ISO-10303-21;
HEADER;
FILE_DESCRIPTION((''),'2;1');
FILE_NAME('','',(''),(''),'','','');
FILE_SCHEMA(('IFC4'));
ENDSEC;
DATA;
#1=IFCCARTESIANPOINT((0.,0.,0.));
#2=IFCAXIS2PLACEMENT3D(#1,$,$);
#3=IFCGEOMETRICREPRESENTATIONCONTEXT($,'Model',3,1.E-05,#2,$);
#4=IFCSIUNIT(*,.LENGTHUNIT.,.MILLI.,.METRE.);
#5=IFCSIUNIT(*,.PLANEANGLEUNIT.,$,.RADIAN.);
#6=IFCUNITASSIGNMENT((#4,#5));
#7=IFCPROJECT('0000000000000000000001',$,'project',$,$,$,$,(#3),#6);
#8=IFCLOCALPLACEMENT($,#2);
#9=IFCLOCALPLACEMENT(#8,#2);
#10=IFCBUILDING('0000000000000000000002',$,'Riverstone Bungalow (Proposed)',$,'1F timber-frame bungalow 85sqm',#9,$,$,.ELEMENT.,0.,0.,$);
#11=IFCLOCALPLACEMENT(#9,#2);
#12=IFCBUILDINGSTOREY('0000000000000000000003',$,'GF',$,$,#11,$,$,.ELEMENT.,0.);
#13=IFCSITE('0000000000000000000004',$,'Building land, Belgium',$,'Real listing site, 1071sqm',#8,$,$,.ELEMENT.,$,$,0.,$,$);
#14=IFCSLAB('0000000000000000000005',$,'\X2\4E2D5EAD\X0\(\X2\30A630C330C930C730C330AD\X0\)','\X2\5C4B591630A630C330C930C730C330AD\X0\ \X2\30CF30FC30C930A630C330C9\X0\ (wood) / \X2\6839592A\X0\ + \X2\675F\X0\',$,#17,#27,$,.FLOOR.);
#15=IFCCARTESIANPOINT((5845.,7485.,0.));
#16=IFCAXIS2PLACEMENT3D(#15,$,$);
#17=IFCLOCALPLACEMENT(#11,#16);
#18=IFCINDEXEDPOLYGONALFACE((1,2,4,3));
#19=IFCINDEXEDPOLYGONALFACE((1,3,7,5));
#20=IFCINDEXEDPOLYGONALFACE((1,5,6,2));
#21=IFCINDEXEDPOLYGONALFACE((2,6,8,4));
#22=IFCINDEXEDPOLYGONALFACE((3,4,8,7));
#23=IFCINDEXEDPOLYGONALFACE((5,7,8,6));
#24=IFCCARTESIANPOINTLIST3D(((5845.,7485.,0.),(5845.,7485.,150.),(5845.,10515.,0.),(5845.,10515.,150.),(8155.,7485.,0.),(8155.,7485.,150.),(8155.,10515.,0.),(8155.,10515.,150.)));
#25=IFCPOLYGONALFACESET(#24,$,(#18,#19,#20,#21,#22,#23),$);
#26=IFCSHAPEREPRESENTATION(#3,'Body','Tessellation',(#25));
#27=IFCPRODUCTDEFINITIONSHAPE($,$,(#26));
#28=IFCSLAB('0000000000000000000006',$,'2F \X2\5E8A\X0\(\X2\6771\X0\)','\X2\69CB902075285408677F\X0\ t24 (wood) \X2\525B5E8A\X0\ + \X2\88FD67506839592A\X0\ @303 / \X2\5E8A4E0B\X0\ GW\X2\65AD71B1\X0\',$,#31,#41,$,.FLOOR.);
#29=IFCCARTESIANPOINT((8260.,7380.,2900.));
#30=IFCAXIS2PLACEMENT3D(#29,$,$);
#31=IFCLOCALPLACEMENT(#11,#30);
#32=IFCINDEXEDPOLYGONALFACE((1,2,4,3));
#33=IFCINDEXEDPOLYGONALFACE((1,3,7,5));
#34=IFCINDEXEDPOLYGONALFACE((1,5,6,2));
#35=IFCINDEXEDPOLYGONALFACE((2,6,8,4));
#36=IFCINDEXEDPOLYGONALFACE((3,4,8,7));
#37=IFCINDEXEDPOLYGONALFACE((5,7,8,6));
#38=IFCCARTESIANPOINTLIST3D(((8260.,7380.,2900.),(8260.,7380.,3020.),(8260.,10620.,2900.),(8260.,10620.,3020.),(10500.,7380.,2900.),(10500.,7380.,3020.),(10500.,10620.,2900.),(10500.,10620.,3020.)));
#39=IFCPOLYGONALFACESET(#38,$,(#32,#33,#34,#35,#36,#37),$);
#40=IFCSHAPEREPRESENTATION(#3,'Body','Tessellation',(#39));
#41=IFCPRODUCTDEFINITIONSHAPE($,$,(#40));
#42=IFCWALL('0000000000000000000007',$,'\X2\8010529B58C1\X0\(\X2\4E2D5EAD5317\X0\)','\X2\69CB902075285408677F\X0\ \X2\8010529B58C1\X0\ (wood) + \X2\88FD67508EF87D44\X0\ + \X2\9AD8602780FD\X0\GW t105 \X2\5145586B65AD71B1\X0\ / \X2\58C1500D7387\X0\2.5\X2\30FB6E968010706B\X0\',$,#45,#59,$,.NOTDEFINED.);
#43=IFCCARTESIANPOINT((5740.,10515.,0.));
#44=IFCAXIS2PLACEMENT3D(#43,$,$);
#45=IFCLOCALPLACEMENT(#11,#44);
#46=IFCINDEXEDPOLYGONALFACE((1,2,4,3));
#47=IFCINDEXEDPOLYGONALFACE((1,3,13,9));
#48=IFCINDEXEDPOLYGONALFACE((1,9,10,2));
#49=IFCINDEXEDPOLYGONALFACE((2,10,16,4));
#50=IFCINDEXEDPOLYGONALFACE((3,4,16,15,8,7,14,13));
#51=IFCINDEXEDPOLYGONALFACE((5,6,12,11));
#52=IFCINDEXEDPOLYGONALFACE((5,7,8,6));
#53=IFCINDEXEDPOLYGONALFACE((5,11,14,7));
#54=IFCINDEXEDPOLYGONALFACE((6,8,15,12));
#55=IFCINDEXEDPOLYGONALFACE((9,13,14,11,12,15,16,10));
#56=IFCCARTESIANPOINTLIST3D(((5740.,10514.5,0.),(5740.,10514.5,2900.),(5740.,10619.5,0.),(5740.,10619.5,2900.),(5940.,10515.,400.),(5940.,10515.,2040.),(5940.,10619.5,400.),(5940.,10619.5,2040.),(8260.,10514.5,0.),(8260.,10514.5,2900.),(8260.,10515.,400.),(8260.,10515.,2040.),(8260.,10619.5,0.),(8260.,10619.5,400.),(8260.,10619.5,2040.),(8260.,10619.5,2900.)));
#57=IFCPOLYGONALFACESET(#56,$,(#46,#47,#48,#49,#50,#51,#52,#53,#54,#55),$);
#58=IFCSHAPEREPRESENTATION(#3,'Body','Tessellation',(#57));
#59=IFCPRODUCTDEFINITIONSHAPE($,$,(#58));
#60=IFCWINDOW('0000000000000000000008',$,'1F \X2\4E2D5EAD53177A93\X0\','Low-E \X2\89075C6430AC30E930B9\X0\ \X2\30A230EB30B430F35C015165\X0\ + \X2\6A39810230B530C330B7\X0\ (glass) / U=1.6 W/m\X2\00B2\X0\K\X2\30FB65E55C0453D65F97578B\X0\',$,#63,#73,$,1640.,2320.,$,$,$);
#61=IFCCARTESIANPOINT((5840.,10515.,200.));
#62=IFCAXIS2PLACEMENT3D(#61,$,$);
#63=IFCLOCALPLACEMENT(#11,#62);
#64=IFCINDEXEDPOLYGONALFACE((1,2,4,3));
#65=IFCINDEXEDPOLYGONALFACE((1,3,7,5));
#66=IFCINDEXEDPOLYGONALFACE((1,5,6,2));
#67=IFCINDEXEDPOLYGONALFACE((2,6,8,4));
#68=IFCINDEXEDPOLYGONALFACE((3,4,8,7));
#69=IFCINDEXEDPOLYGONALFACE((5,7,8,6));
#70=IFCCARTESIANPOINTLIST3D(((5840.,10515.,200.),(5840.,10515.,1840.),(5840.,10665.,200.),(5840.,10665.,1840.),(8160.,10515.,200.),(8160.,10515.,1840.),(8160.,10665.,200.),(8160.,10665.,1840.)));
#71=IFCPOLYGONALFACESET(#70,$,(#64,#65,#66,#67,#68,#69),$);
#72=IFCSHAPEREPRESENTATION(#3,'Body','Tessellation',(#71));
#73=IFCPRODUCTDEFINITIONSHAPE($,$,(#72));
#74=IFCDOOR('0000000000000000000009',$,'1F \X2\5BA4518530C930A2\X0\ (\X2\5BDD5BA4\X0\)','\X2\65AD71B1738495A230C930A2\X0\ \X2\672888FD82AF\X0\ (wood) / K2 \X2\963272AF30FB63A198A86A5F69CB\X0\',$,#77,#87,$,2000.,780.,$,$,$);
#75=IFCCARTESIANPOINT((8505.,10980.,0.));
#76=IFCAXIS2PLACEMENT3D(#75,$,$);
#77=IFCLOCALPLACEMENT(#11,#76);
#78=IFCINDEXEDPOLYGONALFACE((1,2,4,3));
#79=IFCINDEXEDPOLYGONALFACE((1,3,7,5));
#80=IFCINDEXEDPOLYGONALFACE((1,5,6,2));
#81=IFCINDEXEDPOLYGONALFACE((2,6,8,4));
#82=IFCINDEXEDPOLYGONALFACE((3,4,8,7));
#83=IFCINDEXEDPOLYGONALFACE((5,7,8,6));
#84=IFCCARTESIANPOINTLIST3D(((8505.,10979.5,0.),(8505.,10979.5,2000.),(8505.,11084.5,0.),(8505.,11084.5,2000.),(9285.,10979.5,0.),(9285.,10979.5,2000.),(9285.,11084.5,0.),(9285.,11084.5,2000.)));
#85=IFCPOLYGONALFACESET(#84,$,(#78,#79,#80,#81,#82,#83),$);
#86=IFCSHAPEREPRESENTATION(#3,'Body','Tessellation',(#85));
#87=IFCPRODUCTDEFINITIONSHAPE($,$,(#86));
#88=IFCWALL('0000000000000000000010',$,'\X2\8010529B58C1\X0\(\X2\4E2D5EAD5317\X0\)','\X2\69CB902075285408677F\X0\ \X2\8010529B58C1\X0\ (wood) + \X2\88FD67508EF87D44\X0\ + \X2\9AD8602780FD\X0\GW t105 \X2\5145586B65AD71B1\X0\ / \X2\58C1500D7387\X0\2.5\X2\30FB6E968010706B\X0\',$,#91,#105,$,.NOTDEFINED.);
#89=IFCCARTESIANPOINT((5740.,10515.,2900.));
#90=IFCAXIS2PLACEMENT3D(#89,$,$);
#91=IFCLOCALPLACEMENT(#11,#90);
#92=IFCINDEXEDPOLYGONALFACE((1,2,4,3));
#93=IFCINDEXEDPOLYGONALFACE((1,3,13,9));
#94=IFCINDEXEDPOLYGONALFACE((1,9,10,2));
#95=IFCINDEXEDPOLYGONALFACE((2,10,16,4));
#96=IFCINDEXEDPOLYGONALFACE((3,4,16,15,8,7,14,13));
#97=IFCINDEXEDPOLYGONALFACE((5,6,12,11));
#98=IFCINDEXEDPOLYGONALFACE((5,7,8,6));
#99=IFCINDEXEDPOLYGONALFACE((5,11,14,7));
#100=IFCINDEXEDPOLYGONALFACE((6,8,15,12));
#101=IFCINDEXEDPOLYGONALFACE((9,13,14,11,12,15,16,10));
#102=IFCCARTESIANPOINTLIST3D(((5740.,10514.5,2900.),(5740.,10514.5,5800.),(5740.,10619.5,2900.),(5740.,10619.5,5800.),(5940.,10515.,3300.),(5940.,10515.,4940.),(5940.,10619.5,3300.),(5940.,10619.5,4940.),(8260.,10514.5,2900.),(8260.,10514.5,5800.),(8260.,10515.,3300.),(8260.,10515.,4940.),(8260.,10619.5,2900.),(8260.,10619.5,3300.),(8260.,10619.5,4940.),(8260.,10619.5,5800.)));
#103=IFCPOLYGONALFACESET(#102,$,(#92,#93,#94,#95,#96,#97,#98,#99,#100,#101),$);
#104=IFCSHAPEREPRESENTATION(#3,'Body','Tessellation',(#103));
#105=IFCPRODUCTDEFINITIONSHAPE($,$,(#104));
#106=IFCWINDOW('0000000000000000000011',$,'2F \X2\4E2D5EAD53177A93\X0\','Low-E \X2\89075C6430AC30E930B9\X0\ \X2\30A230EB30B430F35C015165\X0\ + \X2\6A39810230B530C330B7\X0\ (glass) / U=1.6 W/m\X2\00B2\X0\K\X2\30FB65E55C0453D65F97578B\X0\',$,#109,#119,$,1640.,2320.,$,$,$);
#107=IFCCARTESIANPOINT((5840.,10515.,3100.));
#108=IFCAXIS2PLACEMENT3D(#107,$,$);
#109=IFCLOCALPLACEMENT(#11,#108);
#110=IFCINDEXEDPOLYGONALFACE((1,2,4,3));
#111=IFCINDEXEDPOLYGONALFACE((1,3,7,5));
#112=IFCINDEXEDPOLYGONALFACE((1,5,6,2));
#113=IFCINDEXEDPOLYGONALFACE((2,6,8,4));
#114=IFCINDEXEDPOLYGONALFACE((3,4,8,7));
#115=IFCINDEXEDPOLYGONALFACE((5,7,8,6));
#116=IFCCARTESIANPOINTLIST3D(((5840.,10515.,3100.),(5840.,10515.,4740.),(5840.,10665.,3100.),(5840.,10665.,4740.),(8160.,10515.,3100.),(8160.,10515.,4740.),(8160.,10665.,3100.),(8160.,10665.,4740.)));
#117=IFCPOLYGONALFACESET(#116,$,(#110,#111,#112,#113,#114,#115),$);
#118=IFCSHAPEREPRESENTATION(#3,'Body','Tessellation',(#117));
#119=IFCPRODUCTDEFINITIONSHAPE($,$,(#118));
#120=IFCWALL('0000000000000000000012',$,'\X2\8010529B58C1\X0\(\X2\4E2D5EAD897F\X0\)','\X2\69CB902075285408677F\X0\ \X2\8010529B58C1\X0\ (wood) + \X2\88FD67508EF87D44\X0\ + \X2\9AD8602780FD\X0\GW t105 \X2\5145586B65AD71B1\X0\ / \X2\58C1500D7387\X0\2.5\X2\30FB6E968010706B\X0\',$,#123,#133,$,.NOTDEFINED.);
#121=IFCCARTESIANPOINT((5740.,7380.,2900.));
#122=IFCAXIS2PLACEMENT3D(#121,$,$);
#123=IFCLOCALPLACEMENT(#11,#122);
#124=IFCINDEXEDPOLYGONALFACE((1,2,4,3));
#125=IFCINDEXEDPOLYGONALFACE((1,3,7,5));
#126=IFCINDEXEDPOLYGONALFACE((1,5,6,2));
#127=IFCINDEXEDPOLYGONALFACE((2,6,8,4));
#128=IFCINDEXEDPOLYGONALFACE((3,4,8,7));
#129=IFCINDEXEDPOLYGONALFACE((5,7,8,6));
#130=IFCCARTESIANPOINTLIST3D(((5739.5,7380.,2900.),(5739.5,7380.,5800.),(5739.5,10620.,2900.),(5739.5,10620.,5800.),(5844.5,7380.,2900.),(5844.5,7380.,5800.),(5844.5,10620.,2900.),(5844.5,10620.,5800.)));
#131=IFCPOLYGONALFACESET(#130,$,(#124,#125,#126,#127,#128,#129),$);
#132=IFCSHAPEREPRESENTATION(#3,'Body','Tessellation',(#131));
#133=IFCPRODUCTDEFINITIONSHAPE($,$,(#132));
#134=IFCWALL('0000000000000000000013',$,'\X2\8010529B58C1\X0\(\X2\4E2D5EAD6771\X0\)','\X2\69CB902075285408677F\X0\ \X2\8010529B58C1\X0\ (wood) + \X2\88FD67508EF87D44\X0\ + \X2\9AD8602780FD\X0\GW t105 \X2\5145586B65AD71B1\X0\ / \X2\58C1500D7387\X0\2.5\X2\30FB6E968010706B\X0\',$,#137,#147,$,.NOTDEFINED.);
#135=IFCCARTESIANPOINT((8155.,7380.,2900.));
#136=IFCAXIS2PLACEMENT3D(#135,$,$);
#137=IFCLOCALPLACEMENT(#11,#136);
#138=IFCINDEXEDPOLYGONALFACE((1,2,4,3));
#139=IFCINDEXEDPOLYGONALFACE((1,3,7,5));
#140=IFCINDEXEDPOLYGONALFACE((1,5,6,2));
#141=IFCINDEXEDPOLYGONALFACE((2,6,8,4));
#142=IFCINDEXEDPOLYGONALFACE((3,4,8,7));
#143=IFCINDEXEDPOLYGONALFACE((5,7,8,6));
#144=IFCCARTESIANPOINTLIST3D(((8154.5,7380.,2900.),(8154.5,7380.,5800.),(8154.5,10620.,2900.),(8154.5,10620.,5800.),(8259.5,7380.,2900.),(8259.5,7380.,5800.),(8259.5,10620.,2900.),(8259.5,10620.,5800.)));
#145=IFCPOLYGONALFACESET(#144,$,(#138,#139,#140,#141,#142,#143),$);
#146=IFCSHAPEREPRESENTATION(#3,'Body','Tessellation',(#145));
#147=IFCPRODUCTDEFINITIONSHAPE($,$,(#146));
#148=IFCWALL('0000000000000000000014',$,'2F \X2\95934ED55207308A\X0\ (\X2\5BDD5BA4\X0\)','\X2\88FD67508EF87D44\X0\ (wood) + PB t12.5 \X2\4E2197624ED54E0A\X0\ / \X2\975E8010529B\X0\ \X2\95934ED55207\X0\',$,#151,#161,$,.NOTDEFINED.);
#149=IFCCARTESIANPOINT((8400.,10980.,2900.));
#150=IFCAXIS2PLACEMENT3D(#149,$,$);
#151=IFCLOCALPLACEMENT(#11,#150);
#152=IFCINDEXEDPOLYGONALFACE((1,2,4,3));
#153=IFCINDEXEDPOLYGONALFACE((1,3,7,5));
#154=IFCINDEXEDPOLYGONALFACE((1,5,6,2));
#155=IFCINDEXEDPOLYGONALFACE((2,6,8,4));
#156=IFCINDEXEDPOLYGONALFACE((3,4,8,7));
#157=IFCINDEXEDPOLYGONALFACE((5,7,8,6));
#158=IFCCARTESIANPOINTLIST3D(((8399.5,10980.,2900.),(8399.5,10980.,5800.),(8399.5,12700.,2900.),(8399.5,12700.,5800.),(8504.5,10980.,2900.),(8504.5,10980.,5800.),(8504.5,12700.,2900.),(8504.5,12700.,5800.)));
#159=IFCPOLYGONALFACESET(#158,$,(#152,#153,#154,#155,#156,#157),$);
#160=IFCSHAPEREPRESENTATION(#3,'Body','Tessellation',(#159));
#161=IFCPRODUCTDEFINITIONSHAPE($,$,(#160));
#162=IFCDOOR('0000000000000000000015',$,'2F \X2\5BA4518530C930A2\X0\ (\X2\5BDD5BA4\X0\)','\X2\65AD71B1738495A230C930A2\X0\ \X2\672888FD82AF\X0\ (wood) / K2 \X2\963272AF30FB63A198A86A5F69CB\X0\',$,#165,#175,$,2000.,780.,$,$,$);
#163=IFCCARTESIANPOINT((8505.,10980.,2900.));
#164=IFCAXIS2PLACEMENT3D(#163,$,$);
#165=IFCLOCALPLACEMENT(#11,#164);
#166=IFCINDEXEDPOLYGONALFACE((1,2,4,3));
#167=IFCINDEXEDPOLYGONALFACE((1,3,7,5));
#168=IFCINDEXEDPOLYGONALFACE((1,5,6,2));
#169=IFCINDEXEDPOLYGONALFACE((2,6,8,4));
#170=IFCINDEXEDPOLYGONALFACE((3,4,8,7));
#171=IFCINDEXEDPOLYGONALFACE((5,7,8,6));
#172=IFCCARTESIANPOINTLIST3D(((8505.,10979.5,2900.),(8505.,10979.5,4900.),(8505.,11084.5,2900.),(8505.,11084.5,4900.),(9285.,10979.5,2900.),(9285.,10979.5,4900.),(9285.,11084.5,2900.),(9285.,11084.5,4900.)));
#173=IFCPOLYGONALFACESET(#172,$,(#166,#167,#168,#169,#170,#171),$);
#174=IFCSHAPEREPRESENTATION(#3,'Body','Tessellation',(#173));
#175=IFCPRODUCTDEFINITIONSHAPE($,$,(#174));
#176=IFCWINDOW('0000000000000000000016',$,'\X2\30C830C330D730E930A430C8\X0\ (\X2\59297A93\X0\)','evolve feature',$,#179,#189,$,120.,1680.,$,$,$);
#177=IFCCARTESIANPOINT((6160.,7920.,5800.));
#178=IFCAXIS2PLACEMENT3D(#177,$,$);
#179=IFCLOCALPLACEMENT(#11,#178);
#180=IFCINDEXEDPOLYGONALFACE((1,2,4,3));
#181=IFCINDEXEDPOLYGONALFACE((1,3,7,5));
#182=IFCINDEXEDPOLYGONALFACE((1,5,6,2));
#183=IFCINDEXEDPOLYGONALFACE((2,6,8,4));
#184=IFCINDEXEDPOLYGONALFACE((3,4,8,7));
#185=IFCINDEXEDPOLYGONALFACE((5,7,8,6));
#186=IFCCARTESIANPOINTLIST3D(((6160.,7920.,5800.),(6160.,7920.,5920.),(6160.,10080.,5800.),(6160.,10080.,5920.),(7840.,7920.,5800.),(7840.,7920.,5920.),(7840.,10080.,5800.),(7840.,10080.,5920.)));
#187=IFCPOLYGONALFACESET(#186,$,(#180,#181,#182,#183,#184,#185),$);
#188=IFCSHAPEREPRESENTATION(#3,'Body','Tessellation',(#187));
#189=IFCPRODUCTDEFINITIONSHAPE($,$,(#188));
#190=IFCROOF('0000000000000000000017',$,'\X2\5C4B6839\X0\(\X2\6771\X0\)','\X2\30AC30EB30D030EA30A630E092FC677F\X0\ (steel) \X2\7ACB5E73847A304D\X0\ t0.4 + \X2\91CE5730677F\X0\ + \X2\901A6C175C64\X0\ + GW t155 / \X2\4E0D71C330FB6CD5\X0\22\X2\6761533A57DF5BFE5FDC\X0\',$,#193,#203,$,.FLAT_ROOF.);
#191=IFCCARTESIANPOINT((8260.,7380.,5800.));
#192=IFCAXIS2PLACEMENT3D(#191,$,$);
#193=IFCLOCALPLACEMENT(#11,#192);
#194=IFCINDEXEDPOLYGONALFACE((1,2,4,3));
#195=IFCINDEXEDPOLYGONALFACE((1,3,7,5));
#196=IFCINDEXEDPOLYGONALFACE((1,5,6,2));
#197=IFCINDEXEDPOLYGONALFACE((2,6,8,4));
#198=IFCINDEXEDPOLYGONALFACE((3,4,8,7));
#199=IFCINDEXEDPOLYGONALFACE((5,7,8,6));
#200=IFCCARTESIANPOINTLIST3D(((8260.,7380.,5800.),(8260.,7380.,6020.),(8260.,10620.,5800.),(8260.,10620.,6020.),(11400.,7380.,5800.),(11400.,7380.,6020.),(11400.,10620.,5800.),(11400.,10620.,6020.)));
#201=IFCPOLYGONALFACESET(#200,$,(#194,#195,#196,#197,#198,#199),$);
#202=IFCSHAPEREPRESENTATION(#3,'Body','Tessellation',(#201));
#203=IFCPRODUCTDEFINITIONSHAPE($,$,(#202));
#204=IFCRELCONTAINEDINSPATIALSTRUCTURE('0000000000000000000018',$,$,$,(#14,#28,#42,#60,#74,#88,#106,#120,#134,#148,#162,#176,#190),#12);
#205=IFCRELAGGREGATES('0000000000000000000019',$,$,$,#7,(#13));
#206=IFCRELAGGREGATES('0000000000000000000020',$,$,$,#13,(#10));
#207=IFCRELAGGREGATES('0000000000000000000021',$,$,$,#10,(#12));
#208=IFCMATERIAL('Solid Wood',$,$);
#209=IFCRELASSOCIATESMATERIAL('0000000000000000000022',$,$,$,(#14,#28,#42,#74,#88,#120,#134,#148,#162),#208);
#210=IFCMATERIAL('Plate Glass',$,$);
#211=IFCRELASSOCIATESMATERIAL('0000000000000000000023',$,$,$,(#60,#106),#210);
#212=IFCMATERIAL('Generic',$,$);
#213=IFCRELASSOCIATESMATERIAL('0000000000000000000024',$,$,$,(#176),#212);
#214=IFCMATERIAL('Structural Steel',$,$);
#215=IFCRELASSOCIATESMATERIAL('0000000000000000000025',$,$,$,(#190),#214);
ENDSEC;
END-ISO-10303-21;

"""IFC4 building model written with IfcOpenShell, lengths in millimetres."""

from ifc_helpers import new_model, si_unit, frame, frame_2d, origin, place, context, project, spatial, rectangle, extrude, material, element, fill, save


model = new_model("IFC4")

# Units and contexts
model_context = context("Model", 3, precision=1e-05, world=origin())
ifc_project = project(units=[si_unit("LENGTHUNIT", "METRE", prefix="MILLI"), si_unit("PLANEANGLEUNIT", "RADIAN")], contexts=[model_context])

# Site, building, storey
site_placement = place(None, origin())
site = spatial("IfcSite", under=ifc_project, at=site_placement, Name="Building land, Belgium", ObjectType="Real listing site, 1071sqm", CompositionType="ELEMENT", RefElevation=0.0)
building_placement = place(site_placement, origin())
building = spatial("IfcBuilding", under=site, at=building_placement, Name="Riverstone Bungalow (Proposed)", ObjectType="1F timber-frame bungalow 85sqm", CompositionType="ELEMENT", ElevationOfRefHeight=0.0, ElevationOfTerrain=0.0)
storey_placement = place(building_placement, origin())
storey = spatial("IfcBuildingStorey", under=building, at=storey_placement, Name="GF", CompositionType="ELEMENT", Elevation=0.0)

# Slabs
ifc_material_1 = material(Name="Solid Wood")
slab_1_placement = place(storey_placement, frame((5845.0, 7485.0, 0.0)))
element("IfcSlab", 1, at=slab_1_placement, inside=storey, material=ifc_material_1, Name="中庭(ウッドデッキ)", Description="屋外ウッドデッキ ハードウッド (wood) / 根太 + 束", PredefinedType="FLOOR", context=model_context, shape_type="SweptSolid", body=[
    extrude(rectangle(XDim=2310.0, YDim=3030.0, at=frame_2d((1155.0, 1515.0))), frame((5845.0, 7485.0, 0.0)), (0.0, 0.0, 1.0), 150.0),
])
slab_2_placement = place(storey_placement, frame((8260.0, 7380.0, 2900.0)))
element("IfcSlab", 2, at=slab_2_placement, inside=storey, material=ifc_material_1, Name="2F 床(東)", Description="構造用合板 t24 (wood) 剛床 + 製材根太 @303 / 床下 GW断熱", PredefinedType="FLOOR", context=model_context, shape_type="SweptSolid", body=[
    extrude(rectangle(XDim=2240.0, YDim=3240.0, at=frame_2d((1120.0, 1620.0))), frame((8260.0, 7380.0, 2900.0)), (0.0, 0.0, 1.0), 120.0),
])

# Wall, opening, window
wall_1_placement = place(storey_placement, frame((5740.0, 10515.0, 0.0)))
wall_1 = element("IfcWall", 3, at=wall_1_placement, inside=storey, material=ifc_material_1, Name="耐力壁(中庭北)", Description="構造用合板 耐力壁 (wood) + 製材軸組 + 高性能GW t105 充填断熱 / 壁倍率2.5・準耐火", PredefinedType="NOTDEFINED", context=model_context, shape_type="SweptSolid", body=[
    extrude(rectangle(XDim=2520.0, YDim=105.0, at=frame_2d((1260.0, 52.0))), frame((5740.0, 10515.0, 0.0)), (0.0, 0.0, 1.0), 2900.0),
])
opening_1_placement = place(storey_placement, frame((5840.0, 10515.0, 200.0)))
opening_1 = element("IfcOpeningElement", 4, at=opening_1_placement, cuts=wall_1, PredefinedType="NOTDEFINED", context=model_context, shape_type="SweptSolid", body=[
    extrude(rectangle(XDim=2320.0, YDim=150.0, at=frame_2d((1160.0, 75.0))), frame((5840.0, 10515.0, 200.0)), (0.0, 0.0, 1.0), 1640.0),
])
ifc_material_2 = material(Name="Plate Glass")
window_1_placement = place(storey_placement, frame((5840.0, 10515.0, 200.0)))
window_1 = element("IfcWindow", 5, at=window_1_placement, inside=storey, material=ifc_material_2, Name="1F 中庭北窓", Description="Low-E 複層ガラス アルゴン封入 + 樹脂サッシ (glass) / U=1.6 W/m²K・日射取得型", OverallHeight=1640.0, OverallWidth=2320.0, context=model_context, shape_type="SweptSolid", body=[
    extrude(rectangle(XDim=2320.0, YDim=150.0, at=frame_2d((1160.0, 75.0))), frame((5840.0, 10515.0, 200.0)), (0.0, 0.0, 1.0), 1640.0),
])
fill(opening_1, window_1)

# Door
door_1_placement = place(storey_placement, frame((8505.0, 10980.0, 0.0)))
element("IfcDoor", 6, at=door_1_placement, inside=storey, material=ifc_material_1, Name="1F 室内ドア (寝室)", Description="断熱玄関ドア 木製芯 (wood) / K2 防犯・採風機構", OverallHeight=2000.0, OverallWidth=780.0, context=model_context, shape_type="SweptSolid", body=[
    extrude(rectangle(XDim=780.0, YDim=105.0, at=frame_2d((390.0, 52.0))), frame((8505.0, 10980.0, 0.0)), (0.0, 0.0, 1.0), 2000.0),
])

# Wall, opening, window
wall_2_placement = place(storey_placement, frame((5740.0, 10515.0, 2900.0)))
wall_2 = element("IfcWall", 7, at=wall_2_placement, inside=storey, material=ifc_material_1, Name="耐力壁(中庭北)", Description="構造用合板 耐力壁 (wood) + 製材軸組 + 高性能GW t105 充填断熱 / 壁倍率2.5・準耐火", PredefinedType="NOTDEFINED", context=model_context, shape_type="SweptSolid", body=[
    extrude(rectangle(XDim=2520.0, YDim=105.0, at=frame_2d((1260.0, 52.0))), frame((5740.0, 10515.0, 2900.0)), (0.0, 0.0, 1.0), 2900.0),
])
opening_2_placement = place(storey_placement, frame((5840.0, 10515.0, 3100.0)))
opening_2 = element("IfcOpeningElement", 8, at=opening_2_placement, cuts=wall_2, PredefinedType="NOTDEFINED", context=model_context, shape_type="SweptSolid", body=[
    extrude(rectangle(XDim=2320.0, YDim=150.0, at=frame_2d((1160.0, 75.0))), frame((5840.0, 10515.0, 3100.0)), (0.0, 0.0, 1.0), 1640.0),
])
window_2_placement = place(storey_placement, frame((5840.0, 10515.0, 3100.0)))
window_2 = element("IfcWindow", 9, at=window_2_placement, inside=storey, material=ifc_material_2, Name="2F 中庭北窓", Description="Low-E 複層ガラス アルゴン封入 + 樹脂サッシ (glass) / U=1.6 W/m²K・日射取得型", OverallHeight=1640.0, OverallWidth=2320.0, context=model_context, shape_type="SweptSolid", body=[
    extrude(rectangle(XDim=2320.0, YDim=150.0, at=frame_2d((1160.0, 75.0))), frame((5840.0, 10515.0, 3100.0)), (0.0, 0.0, 1.0), 1640.0),
])
fill(opening_2, window_2)

# Walls
wall_3_placement = place(storey_placement, frame((5740.0, 7380.0, 2900.0)))
element("IfcWall", 10, at=wall_3_placement, inside=storey, material=ifc_material_1, Name="耐力壁(中庭西)", Description="構造用合板 耐力壁 (wood) + 製材軸組 + 高性能GW t105 充填断熱 / 壁倍率2.5・準耐火", PredefinedType="NOTDEFINED", context=model_context, shape_type="SweptSolid", body=[
    extrude(rectangle(XDim=105.0, YDim=3240.0, at=frame_2d((52.0, 1620.0))), frame((5740.0, 7380.0, 2900.0)), (0.0, 0.0, 1.0), 2900.0),
])
wall_4_placement = place(storey_placement, frame((8155.0, 7380.0, 2900.0)))
element("IfcWall", 11, at=wall_4_placement, inside=storey, material=ifc_material_1, Name="耐力壁(中庭東)", Description="構造用合板 耐力壁 (wood) + 製材軸組 + 高性能GW t105 充填断熱 / 壁倍率2.5・準耐火", PredefinedType="NOTDEFINED", context=model_context, shape_type="SweptSolid", body=[
    extrude(rectangle(XDim=105.0, YDim=3240.0, at=frame_2d((52.0, 1620.0))), frame((8155.0, 7380.0, 2900.0)), (0.0, 0.0, 1.0), 2900.0),
])
wall_5_placement = place(storey_placement, frame((8400.0, 10980.0, 2900.0)))
element("IfcWall", 12, at=wall_5_placement, inside=storey, material=ifc_material_1, Name="2F 間仕切り (寝室)", Description="製材軸組 (wood) + PB t12.5 両面仕上 / 非耐力 間仕切", PredefinedType="NOTDEFINED", context=model_context, shape_type="SweptSolid", body=[
    extrude(rectangle(XDim=105.0, YDim=1720.0, at=frame_2d((52.0, 860.0))), frame((8400.0, 10980.0, 2900.0)), (0.0, 0.0, 1.0), 2900.0),
])

# Door
door_2_placement = place(storey_placement, frame((8505.0, 10980.0, 2900.0)))
element("IfcDoor", 13, at=door_2_placement, inside=storey, material=ifc_material_1, Name="2F 室内ドア (寝室)", Description="断熱玄関ドア 木製芯 (wood) / K2 防犯・採風機構", OverallHeight=2000.0, OverallWidth=780.0, context=model_context, shape_type="SweptSolid", body=[
    extrude(rectangle(XDim=780.0, YDim=105.0, at=frame_2d((390.0, 52.0))), frame((8505.0, 10980.0, 2900.0)), (0.0, 0.0, 1.0), 2000.0),
])

# Window
ifc_material_3 = material(Name="Generic")
window_3_placement = place(storey_placement, frame((6160.0, 7920.0, 5800.0)))
element("IfcWindow", 14, at=window_3_placement, inside=storey, material=ifc_material_3, Name="トップライト (天窓)", Description="evolve feature", OverallHeight=120.0, OverallWidth=1680.0, context=model_context, shape_type="SweptSolid", body=[
    extrude(rectangle(XDim=1680.0, YDim=2160.0, at=frame_2d((840.0, 1080.0))), frame((6160.0, 7920.0, 5800.0)), (0.0, 0.0, 1.0), 120.0),
])

# Roof
ifc_material_4 = material(Name="Structural Steel")
roof_placement = place(storey_placement, frame((8260.0, 7380.0, 5800.0)))
element("IfcRoof", 15, at=roof_placement, inside=storey, material=ifc_material_4, Name="屋根(東)", Description="ガルバリウム鋼板 (steel) 立平葺き t0.4 + 野地板 + 通気層 + GW t155 / 不燃・法22条区域対応", PredefinedType="FLAT_ROOF", context=model_context, shape_type="SweptSolid", body=[
    extrude(rectangle(XDim=3140.0, YDim=3240.0, at=frame_2d((1570.0, 1620.0))), frame((8260.0, 7380.0, 5800.0)), (0.0, 0.0, 1.0), 220.0),
])

save(model, "model.ifc")
